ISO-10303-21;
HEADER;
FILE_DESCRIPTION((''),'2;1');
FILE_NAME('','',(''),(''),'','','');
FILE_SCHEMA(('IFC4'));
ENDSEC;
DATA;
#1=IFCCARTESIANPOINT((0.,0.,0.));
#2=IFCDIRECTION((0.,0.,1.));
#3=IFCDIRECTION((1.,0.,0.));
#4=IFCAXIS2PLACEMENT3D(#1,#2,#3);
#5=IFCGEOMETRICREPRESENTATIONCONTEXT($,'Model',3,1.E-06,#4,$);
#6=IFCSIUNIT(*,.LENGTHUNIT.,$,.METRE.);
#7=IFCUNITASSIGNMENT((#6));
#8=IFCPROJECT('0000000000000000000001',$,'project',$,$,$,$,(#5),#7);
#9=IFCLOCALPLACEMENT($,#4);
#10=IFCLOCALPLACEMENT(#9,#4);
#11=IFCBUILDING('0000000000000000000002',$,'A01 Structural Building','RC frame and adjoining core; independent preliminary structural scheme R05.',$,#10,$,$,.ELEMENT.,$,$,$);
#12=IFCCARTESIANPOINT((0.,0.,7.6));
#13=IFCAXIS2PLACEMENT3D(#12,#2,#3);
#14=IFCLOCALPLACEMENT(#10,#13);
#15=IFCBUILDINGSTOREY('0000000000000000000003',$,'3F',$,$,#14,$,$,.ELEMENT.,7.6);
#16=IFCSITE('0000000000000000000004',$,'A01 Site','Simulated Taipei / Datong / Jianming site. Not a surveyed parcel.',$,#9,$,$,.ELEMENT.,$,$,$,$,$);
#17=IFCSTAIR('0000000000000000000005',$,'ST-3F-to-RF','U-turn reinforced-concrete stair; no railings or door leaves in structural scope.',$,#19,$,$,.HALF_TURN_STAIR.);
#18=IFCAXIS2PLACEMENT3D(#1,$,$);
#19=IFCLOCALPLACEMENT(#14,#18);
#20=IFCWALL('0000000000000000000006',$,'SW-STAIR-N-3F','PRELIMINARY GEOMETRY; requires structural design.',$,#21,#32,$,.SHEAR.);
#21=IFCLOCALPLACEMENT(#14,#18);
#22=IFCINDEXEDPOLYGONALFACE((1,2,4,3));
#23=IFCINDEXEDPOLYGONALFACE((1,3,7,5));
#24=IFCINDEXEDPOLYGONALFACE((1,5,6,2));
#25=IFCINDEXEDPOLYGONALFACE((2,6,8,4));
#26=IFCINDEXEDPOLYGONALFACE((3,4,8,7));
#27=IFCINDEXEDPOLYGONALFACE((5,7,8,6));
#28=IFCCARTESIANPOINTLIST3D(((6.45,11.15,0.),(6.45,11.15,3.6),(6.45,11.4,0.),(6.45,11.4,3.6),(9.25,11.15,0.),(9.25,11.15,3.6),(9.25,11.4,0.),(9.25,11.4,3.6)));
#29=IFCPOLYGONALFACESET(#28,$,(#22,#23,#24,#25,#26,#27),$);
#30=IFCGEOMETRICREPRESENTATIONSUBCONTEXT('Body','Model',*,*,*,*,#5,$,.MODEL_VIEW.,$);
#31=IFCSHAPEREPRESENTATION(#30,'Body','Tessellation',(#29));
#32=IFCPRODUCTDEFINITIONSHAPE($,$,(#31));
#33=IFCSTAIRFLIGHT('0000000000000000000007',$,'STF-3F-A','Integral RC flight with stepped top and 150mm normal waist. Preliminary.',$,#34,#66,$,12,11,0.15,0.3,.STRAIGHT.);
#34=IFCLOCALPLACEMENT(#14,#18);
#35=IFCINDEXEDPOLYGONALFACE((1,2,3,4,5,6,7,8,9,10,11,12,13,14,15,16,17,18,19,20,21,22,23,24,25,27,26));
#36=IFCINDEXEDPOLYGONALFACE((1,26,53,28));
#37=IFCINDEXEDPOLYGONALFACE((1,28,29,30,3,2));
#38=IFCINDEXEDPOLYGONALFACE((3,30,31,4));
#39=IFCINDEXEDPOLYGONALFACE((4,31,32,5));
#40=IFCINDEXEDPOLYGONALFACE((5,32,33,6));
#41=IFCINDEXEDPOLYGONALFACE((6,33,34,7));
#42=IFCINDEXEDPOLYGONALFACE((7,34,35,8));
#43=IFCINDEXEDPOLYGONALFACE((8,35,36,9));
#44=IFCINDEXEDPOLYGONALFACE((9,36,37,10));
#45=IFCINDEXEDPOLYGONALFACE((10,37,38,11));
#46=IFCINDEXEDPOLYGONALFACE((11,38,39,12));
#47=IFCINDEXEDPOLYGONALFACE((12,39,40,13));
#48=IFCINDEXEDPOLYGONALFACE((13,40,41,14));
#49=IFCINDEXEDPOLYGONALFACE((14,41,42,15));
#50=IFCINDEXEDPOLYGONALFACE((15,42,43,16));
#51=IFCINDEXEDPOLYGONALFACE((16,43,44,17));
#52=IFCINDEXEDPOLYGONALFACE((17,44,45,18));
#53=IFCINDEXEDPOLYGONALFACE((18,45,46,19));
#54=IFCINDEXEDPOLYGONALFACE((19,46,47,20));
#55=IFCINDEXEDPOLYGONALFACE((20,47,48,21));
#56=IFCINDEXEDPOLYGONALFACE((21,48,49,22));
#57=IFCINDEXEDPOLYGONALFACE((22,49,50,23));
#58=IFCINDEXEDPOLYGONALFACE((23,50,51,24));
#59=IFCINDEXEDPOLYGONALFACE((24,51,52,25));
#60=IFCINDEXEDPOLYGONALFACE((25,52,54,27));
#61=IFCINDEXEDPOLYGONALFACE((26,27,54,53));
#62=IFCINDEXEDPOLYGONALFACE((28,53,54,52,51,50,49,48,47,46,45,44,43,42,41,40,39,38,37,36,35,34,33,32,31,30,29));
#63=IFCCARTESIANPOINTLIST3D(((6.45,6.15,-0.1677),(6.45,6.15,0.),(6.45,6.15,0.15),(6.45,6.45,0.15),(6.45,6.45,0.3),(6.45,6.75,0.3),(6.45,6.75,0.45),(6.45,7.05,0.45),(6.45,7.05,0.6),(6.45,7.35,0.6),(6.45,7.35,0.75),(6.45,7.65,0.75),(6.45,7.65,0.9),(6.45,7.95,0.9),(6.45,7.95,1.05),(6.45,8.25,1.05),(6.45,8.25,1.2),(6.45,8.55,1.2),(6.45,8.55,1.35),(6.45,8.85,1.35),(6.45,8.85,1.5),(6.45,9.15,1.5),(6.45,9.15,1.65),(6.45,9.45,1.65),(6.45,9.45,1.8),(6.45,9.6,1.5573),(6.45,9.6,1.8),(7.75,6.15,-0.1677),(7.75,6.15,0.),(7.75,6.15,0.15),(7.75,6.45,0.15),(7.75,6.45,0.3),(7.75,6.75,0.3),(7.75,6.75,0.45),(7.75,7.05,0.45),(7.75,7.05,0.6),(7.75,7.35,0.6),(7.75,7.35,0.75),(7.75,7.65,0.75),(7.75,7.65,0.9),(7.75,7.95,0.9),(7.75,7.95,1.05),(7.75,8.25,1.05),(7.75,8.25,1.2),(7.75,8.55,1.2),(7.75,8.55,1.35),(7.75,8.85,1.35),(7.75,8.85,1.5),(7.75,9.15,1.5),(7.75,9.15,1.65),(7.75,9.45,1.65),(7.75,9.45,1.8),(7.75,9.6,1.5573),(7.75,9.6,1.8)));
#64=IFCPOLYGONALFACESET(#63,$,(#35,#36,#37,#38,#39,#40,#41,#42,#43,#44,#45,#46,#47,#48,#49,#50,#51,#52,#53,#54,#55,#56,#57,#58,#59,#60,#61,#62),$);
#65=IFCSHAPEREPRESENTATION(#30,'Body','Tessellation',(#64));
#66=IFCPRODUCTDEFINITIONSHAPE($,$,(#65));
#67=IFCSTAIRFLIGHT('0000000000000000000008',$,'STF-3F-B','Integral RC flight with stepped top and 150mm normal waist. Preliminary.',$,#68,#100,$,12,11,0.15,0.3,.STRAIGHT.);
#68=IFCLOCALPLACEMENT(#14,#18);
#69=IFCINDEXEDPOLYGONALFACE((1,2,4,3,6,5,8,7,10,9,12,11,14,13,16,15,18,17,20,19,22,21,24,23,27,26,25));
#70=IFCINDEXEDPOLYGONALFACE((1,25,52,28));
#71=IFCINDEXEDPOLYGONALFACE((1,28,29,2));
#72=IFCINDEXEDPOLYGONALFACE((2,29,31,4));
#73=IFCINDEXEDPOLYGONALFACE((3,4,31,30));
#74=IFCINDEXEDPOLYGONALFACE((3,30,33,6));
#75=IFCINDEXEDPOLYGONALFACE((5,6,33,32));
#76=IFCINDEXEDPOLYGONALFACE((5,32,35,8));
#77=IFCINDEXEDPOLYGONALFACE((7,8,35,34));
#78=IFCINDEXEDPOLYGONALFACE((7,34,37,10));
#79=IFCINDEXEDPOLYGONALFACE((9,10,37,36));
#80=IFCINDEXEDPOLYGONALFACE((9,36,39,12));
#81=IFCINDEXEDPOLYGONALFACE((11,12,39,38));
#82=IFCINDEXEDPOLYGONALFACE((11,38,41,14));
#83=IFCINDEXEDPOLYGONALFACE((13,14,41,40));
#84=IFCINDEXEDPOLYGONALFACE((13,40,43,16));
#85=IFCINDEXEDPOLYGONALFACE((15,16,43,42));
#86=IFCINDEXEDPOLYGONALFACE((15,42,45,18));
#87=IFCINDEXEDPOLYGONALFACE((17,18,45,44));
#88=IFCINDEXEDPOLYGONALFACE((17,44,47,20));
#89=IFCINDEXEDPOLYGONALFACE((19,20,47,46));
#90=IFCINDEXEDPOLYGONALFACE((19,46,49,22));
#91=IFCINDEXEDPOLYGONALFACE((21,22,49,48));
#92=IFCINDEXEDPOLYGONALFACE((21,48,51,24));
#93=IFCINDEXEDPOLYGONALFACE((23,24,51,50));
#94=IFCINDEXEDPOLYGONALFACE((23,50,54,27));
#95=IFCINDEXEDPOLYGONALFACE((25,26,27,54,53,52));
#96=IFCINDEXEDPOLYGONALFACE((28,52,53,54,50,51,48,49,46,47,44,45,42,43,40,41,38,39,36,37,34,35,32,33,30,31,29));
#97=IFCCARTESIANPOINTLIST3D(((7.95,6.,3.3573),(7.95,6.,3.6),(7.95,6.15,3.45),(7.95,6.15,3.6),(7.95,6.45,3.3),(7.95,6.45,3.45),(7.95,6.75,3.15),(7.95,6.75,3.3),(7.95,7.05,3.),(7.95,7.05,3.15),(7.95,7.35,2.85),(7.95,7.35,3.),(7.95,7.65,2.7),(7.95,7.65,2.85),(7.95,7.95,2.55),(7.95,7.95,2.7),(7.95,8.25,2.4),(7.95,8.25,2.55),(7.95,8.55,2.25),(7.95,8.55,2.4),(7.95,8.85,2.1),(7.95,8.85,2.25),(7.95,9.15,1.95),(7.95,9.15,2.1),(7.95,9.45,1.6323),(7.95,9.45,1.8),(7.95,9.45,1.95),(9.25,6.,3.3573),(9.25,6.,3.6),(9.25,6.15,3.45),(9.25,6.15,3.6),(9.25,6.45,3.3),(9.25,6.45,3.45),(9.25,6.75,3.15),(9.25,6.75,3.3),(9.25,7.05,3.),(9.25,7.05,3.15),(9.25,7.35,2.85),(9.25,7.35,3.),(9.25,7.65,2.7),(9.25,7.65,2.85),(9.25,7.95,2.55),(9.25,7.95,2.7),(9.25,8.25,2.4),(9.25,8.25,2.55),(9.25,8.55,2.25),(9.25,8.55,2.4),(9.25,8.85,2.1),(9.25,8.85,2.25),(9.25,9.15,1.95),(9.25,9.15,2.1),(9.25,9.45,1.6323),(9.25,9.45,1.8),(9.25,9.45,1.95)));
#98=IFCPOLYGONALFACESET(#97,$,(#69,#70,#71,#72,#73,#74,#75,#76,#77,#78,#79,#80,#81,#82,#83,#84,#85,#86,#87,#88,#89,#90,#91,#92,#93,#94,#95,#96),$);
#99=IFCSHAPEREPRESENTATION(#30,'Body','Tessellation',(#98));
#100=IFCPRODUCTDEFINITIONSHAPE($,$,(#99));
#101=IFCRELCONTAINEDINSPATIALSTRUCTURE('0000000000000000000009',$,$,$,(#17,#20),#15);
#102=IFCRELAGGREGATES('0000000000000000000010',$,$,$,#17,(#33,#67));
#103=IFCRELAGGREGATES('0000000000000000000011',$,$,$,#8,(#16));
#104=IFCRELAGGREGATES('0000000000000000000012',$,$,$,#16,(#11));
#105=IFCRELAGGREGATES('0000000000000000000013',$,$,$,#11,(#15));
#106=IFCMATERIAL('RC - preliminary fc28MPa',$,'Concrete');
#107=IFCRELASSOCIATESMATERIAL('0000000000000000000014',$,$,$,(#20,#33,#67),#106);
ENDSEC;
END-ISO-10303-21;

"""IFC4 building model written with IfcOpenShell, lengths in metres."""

from ifc_helpers import new_model, si_unit, frame, origin_with_axes, place, context, subcontext, project, spatial, polyline, rectangle, outline, extrude, material, element, aggregate, save


model = new_model("IFC4")

# Units and contexts
model_context = context("Model", 3, precision=1e-06, world=origin_with_axes())
body_context = subcontext(model_context, "Body", "Model", "MODEL_VIEW")
ifc_project = project(units=[si_unit("LENGTHUNIT", "METRE")], contexts=[model_context])

# Site, building, storey
site_placement = place(None, origin_with_axes())
site = spatial("IfcSite", under=ifc_project, at=site_placement, Name="A01 Site", Description="Simulated Taipei / Datong / Jianming site. Not a surveyed parcel.", CompositionType="ELEMENT")
building_placement = place(site_placement, origin_with_axes())
building = spatial("IfcBuilding", under=site, at=building_placement, Name="A01 Structural Building", Description="RC frame and adjoining core; independent preliminary structural scheme R05.", CompositionType="ELEMENT")
storey_placement = place(building_placement, frame((0.0, 0.0, 7.6), z_axis=(0.0, 0.0, 1.0), x_axis=(1.0, 0.0, 0.0)))
storey = spatial("IfcBuildingStorey", under=building, at=storey_placement, Name="3F", CompositionType="ELEMENT", Elevation=7.6)

# Shared definitions
ifc_material = material(Name="RC - preliminary fc28MPa", Category="Concrete")

# Stair
stair_placement = place(storey_placement, origin_with_axes())
stair = element("IfcStair", 1, at=stair_placement, inside=storey, Name="ST-3F-to-RF", Description="U-turn reinforced-concrete stair; no railings or door leaves in structural scope.", PredefinedType="HALF_TURN_STAIR")

# Wall
wall_1_placement = place(storey_placement, frame((7.85, 11.275, 0.0), z_axis=(0.0, 0.0, 1.0), x_axis=(1.0, 0.0, 0.0)))
element("IfcWall", 2, at=wall_1_placement, inside=storey, material=ifc_material, Name="SW-STAIR-N-3F", Description="PRELIMINARY GEOMETRY; requires structural design.", PredefinedType="SHEAR", context=body_context, shape_type="SweptSolid", body=[
    extrude(rectangle(XDim=2.8, YDim=0.25), origin_with_axes(), (0.0, 0.0, 1.0), 3.6),
])

# Stair flights
stair_flight_1_placement = place(storey_placement, origin_with_axes())
stair_flight_1 = element("IfcStairFlight", 3, at=stair_flight_1_placement, material=ifc_material, Name="STF-3F-A", Description="Integral RC flight with stepped top and 150mm normal waist. Preliminary.", NumberOfRisers=12, NumberOfTreads=11, PredefinedType="STRAIGHT", RiserHeight=0.15, TreadLength=0.3, context=body_context, shape_type="SweptSolid", body=[
    extrude(outline(polyline([(0.0, 0.0), (0.0, 0.15), (0.3, 0.15), (0.3, 0.3), (0.6, 0.3), (0.6, 0.45), (0.9, 0.45), (0.9, 0.6), (1.2, 0.6), (1.2, 0.75), (1.5, 0.75), (1.5, 0.9), (1.8, 0.9), (1.8, 1.05), (2.1, 1.05), (2.1, 1.2), (2.4, 1.2), (2.4, 1.35), (2.7, 1.35), (2.7, 1.5), (3.0, 1.5), (3.0, 1.65), (3.3, 1.65), (3.3, 1.8), (3.45, 1.8), (3.45, 1.5573), (0.0, -0.1677), (0.0, 0.0)])), frame((6.45, 6.15, 0.0), z_axis=(1.0, 0.0, 0.0), x_axis=(0.0, 1.0, 0.0)), (0.0, 0.0, 1.0), 1.3),
])
stair_flight_2_placement = place(storey_placement, origin_with_axes())
stair_flight_2 = element("IfcStairFlight", 4, at=stair_flight_2_placement, material=ifc_material, Name="STF-3F-B", Description="Integral RC flight with stepped top and 150mm normal waist. Preliminary.", NumberOfRisers=12, NumberOfTreads=11, PredefinedType="STRAIGHT", RiserHeight=0.15, TreadLength=0.3, context=body_context, shape_type="SweptSolid", body=[
    extrude(outline(polyline([(0.0, 0.0), (0.0, 0.15), (0.3, 0.15), (0.3, 0.3), (0.6, 0.3), (0.6, 0.45), (0.9, 0.45), (0.9, 0.6), (1.2, 0.6), (1.2, 0.75), (1.5, 0.75), (1.5, 0.9), (1.8, 0.9), (1.8, 1.05), (2.1, 1.05), (2.1, 1.2), (2.4, 1.2), (2.4, 1.35), (2.7, 1.35), (2.7, 1.5), (3.0, 1.5), (3.0, 1.65), (3.3, 1.65), (3.3, 1.8), (3.45, 1.8), (3.45, 1.5573), (0.0, -0.1677), (0.0, 0.0)])), frame((9.25, 9.45, 1.8), z_axis=(-1.0, 0.0, 0.0), x_axis=(0.0, -1.0, 0.0)), (0.0, 0.0, 1.0), 1.3),
])
aggregate(stair, [stair_flight_1, stair_flight_2])

save(model, "model.ifc")
